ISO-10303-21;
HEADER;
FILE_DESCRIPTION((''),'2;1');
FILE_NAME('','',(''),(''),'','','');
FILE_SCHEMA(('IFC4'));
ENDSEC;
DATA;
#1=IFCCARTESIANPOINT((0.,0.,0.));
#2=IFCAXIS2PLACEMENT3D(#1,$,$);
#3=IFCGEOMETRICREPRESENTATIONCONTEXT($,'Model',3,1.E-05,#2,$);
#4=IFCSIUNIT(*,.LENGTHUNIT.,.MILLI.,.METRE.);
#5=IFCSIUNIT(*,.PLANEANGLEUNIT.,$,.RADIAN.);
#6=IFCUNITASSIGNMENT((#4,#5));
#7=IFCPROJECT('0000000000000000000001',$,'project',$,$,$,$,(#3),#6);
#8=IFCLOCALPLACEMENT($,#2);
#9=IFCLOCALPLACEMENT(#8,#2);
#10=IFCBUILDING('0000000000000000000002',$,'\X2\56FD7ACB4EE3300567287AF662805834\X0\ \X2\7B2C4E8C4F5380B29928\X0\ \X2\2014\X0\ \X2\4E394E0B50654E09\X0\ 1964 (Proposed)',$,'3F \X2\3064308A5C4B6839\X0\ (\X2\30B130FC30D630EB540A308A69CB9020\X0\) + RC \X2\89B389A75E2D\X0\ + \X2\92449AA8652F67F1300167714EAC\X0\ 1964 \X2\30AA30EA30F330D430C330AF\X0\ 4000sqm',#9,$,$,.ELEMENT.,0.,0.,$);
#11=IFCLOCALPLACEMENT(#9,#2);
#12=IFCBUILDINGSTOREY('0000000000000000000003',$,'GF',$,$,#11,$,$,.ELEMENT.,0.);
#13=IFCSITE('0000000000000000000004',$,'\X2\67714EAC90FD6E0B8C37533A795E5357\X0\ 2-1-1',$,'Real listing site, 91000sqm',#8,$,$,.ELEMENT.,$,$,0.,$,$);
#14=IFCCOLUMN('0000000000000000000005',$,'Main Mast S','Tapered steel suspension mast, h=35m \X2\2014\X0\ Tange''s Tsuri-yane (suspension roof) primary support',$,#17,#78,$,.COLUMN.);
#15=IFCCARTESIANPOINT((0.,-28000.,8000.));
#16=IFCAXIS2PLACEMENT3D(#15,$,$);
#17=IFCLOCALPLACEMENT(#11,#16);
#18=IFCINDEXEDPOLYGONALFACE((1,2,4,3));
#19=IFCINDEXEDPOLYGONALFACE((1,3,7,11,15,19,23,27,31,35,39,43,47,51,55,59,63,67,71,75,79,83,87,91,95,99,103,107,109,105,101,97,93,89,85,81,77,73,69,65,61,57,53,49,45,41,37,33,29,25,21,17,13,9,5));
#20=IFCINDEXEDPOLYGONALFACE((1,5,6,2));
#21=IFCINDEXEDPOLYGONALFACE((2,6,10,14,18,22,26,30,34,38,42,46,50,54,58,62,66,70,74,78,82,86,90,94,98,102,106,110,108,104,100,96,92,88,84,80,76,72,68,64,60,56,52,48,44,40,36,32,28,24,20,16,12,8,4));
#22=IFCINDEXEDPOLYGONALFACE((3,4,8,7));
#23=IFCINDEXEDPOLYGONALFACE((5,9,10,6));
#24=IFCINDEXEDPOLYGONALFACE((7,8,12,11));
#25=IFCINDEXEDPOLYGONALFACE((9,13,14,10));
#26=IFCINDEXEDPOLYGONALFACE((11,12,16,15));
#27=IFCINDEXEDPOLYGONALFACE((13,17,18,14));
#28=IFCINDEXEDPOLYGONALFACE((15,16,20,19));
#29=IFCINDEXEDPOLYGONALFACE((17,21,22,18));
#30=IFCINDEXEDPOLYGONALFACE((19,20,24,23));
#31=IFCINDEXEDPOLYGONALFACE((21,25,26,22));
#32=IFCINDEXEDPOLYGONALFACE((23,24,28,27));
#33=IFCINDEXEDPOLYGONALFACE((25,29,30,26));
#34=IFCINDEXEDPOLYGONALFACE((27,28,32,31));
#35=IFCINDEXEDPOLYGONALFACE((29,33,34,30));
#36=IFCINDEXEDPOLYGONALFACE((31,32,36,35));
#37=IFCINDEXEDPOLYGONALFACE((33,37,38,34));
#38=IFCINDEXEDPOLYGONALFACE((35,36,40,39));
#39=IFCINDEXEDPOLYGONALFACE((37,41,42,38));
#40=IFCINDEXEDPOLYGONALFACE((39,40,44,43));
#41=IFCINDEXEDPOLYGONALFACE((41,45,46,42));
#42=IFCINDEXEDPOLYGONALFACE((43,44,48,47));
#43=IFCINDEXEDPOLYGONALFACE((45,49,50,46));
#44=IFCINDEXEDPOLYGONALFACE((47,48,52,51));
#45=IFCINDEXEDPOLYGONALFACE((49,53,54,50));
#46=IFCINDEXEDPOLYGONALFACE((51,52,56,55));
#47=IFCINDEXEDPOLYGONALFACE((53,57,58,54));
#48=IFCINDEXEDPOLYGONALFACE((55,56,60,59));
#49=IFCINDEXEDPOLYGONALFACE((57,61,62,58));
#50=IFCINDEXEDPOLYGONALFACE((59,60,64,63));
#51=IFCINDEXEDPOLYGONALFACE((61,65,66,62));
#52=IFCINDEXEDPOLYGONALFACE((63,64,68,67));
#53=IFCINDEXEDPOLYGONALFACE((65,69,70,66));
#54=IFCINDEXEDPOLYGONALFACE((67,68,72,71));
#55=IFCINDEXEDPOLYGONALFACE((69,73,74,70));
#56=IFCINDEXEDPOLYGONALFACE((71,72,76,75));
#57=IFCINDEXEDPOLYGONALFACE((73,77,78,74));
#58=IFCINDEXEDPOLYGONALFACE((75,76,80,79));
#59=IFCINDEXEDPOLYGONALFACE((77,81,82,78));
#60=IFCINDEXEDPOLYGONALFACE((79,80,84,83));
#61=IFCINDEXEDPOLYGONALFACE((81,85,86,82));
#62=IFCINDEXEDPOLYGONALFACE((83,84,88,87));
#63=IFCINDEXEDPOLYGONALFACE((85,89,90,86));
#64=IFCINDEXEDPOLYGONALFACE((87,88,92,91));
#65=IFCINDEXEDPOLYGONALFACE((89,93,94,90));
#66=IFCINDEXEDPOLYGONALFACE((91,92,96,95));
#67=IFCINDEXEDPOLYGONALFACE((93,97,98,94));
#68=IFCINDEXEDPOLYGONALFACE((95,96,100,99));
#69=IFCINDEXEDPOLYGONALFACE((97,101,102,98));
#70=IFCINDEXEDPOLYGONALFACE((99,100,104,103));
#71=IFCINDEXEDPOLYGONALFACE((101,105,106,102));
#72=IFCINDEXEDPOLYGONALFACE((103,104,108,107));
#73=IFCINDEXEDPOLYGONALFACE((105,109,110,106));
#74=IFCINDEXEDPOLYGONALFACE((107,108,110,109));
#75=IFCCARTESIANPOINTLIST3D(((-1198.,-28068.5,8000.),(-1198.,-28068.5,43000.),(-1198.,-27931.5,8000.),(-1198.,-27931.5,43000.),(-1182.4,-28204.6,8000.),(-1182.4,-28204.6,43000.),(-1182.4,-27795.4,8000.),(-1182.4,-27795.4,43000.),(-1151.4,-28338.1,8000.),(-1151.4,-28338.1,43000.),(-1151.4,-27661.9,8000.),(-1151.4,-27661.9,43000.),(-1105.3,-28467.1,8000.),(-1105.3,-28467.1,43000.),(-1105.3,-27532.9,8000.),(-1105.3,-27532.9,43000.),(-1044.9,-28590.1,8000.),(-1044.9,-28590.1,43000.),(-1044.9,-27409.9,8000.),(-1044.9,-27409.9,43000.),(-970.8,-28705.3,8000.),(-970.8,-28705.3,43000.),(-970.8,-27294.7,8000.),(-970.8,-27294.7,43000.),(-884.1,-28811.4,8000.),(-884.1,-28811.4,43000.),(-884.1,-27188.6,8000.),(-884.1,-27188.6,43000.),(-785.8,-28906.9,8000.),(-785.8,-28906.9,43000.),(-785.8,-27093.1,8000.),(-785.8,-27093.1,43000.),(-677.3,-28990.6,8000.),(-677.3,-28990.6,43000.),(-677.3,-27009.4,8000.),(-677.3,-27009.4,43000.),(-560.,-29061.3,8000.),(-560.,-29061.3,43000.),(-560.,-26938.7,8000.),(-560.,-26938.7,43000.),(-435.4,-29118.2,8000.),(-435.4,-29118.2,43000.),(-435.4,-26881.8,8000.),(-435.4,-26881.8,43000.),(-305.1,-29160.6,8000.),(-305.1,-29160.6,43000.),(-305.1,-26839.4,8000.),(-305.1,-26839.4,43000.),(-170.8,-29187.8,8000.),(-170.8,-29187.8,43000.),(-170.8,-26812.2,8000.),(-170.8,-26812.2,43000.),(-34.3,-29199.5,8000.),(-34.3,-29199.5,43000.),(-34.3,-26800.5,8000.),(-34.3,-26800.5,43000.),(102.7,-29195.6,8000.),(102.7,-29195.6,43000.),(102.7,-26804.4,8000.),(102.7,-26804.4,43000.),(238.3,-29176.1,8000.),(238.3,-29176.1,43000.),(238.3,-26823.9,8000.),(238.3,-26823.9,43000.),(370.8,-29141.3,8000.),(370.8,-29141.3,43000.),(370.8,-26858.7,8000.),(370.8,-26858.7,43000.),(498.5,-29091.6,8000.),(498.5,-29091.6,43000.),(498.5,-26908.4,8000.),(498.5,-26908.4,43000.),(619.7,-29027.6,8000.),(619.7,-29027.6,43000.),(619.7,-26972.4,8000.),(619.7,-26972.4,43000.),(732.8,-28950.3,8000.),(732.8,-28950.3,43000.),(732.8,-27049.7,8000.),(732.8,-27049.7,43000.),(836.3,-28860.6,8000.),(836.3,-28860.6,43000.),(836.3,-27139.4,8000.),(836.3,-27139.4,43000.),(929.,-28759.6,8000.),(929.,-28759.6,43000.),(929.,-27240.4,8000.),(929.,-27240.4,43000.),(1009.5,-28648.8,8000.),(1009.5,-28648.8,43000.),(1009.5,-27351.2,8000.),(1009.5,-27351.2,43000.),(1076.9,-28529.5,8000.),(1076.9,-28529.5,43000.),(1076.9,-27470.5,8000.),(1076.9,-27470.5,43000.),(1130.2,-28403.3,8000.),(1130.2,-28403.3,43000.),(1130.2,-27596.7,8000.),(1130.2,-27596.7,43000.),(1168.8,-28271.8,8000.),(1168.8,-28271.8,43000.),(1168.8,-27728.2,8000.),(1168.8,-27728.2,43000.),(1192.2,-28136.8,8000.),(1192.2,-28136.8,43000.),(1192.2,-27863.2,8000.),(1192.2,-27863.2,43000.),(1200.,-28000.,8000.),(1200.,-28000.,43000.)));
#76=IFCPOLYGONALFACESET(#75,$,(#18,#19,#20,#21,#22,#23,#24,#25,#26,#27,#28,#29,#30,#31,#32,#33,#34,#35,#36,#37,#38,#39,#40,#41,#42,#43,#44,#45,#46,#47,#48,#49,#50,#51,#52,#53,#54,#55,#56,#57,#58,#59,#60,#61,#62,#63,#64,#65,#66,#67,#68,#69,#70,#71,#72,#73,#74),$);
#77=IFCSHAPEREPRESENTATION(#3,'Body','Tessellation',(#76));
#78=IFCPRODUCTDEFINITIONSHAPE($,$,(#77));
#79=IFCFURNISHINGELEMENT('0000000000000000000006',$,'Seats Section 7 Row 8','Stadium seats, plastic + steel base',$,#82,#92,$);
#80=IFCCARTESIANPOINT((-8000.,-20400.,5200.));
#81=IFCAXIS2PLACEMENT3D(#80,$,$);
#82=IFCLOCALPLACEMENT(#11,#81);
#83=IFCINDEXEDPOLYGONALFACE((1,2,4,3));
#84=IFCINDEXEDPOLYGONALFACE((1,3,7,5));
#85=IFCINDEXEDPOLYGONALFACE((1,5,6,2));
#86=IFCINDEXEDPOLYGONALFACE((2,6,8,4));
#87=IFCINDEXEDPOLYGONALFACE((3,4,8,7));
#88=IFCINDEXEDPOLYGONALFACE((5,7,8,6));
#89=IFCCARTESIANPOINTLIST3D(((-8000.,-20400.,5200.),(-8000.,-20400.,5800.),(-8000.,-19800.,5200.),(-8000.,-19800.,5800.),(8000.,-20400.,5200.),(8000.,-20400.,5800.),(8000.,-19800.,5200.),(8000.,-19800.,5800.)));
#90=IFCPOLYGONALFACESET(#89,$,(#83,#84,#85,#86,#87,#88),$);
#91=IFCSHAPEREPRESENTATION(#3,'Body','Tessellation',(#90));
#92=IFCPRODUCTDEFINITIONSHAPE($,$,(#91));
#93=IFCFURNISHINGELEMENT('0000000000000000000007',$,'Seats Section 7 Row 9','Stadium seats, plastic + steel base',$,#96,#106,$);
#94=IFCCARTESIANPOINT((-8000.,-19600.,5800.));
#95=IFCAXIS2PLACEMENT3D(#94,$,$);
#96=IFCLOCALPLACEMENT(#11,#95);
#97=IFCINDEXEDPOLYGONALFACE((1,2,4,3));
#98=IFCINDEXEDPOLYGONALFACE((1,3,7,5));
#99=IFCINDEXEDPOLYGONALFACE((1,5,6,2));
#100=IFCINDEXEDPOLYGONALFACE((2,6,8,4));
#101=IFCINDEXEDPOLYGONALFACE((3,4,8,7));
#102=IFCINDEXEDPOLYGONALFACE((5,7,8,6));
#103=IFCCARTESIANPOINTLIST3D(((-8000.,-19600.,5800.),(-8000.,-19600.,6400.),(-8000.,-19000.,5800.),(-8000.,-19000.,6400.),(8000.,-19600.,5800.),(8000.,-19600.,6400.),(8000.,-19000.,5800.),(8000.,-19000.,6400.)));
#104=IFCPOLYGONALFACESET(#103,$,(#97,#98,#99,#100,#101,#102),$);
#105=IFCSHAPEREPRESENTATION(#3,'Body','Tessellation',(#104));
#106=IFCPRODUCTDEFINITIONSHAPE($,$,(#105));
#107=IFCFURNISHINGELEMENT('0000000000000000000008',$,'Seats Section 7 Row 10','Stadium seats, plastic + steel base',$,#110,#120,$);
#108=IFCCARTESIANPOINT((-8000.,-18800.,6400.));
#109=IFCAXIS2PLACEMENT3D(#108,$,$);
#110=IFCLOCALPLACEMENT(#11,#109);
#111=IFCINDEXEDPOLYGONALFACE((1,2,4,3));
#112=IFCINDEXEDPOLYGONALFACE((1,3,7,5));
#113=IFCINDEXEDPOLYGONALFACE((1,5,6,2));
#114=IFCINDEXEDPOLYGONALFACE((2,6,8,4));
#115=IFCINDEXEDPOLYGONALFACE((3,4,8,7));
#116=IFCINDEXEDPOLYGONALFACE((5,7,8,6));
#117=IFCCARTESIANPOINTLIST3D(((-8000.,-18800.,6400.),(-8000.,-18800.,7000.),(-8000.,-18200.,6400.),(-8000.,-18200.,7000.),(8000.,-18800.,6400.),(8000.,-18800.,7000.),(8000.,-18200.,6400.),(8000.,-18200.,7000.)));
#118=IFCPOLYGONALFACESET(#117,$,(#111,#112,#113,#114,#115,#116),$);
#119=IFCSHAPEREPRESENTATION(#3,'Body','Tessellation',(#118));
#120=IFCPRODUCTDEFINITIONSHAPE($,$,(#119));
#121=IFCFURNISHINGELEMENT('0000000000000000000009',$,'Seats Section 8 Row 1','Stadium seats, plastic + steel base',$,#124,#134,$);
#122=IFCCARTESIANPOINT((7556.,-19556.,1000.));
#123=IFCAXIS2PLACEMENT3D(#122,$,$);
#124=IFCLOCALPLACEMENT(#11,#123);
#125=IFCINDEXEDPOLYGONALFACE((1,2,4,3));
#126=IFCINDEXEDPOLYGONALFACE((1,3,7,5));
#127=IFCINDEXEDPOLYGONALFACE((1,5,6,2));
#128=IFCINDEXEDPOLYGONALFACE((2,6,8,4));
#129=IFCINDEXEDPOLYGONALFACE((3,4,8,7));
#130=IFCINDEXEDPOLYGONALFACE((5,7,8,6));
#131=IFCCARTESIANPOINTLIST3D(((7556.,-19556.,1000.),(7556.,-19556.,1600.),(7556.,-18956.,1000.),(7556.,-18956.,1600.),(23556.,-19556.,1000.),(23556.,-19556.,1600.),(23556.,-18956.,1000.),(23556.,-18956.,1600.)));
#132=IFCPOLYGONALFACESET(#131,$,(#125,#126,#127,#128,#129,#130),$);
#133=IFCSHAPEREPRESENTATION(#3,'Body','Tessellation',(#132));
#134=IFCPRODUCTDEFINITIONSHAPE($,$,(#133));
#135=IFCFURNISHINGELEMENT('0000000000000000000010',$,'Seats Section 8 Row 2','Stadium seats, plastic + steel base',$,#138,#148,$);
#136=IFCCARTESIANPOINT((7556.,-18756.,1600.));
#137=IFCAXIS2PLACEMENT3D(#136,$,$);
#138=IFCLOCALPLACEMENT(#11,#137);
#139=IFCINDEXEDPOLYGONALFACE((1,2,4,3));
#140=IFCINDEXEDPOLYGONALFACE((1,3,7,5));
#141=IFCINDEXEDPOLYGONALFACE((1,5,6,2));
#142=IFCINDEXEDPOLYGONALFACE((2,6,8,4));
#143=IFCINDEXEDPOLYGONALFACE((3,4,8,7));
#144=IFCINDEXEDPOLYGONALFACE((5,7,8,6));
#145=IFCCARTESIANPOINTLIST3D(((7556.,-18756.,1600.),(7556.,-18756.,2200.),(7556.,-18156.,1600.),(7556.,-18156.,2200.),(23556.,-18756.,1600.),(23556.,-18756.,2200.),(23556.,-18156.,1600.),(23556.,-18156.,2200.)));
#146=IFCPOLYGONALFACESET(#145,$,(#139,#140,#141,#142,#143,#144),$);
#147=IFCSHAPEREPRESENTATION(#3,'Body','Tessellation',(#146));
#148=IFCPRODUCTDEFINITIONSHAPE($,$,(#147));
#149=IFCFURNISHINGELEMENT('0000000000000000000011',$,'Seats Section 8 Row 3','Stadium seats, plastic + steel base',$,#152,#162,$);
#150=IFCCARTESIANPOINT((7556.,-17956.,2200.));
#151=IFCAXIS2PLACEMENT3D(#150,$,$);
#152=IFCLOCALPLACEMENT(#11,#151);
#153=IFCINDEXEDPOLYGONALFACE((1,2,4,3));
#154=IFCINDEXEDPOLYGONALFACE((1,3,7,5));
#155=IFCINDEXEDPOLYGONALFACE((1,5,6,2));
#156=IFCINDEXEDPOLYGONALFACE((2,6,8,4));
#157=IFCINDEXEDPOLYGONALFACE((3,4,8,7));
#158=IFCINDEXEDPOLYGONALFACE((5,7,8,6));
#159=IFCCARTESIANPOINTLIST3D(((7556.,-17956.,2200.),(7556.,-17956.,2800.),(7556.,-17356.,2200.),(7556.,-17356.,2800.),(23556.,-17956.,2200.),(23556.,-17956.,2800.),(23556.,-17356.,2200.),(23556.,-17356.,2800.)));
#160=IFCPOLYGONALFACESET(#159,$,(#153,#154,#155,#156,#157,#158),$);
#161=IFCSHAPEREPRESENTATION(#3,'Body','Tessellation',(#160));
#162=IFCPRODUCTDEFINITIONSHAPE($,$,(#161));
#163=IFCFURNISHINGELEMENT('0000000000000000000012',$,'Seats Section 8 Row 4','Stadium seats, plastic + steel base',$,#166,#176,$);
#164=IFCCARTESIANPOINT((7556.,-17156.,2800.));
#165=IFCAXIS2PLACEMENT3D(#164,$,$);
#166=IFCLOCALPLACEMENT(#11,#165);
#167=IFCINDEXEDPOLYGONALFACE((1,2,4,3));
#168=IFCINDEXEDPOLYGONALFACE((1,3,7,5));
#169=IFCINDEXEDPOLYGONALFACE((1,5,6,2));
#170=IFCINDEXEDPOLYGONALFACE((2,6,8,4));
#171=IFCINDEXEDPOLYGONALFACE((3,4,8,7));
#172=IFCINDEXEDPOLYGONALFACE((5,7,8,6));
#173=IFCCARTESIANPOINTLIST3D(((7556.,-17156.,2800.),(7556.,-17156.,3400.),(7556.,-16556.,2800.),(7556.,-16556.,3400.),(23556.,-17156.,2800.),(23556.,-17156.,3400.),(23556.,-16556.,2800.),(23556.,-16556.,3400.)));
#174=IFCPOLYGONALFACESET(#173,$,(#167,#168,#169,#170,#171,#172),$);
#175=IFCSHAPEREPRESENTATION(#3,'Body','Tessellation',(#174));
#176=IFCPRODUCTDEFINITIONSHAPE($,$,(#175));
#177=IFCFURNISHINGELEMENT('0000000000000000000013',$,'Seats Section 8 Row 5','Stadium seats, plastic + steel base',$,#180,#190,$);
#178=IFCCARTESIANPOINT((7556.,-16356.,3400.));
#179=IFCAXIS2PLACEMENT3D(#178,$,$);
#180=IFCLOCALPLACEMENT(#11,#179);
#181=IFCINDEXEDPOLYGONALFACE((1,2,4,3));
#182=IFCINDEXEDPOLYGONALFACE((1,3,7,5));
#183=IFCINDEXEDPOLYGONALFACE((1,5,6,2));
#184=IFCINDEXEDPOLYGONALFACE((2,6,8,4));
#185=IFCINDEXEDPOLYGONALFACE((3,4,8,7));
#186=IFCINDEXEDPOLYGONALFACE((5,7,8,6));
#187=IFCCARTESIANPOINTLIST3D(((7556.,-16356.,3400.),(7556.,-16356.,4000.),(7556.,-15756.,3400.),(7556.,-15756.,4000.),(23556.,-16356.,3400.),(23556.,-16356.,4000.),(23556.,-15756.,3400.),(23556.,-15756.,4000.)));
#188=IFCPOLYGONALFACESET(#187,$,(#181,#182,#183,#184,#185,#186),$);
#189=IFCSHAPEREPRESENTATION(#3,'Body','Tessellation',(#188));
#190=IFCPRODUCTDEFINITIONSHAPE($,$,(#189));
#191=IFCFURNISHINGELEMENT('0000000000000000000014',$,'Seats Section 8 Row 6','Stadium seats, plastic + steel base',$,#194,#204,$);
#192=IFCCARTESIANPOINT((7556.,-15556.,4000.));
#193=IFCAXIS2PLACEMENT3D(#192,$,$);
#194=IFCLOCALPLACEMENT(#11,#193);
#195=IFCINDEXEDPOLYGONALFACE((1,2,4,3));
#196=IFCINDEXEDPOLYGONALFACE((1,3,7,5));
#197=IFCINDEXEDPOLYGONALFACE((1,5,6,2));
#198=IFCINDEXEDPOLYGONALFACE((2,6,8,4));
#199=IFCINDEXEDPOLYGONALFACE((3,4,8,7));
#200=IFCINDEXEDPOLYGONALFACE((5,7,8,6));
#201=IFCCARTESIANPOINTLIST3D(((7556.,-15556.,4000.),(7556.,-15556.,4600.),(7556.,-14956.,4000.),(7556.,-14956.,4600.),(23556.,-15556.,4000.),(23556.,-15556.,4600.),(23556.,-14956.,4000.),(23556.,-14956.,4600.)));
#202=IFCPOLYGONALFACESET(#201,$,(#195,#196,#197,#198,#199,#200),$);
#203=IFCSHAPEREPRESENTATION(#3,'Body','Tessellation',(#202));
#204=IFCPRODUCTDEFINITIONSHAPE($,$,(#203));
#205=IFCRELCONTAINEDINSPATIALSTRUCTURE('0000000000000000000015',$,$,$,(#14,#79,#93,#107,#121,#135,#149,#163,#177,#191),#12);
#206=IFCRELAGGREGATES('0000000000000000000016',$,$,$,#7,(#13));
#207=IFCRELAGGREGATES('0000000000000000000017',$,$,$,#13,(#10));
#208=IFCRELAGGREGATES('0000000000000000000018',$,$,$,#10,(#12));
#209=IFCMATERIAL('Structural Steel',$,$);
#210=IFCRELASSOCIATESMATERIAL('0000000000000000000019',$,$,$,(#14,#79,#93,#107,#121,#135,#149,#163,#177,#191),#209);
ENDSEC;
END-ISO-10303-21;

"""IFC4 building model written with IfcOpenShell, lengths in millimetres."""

from ifc_helpers import new_model, si_unit, frame, frame_2d, origin, origin_2d, place, context, project, spatial, rectangle, circle, extrude, material, element, save


model = new_model("IFC4")

# Units and contexts
model_context = context("Model", 3, precision=1e-05, world=origin())
ifc_project = project(units=[si_unit("LENGTHUNIT", "METRE", prefix="MILLI"), si_unit("PLANEANGLEUNIT", "RADIAN")], contexts=[model_context])

# Site, building, storey
site_placement = place(None, origin())
site = spatial("IfcSite", under=ifc_project, at=site_placement, Name="東京都渋谷区神南 2-1-1", ObjectType="Real listing site, 91000sqm", CompositionType="ELEMENT", RefElevation=0.0)
building_placement = place(site_placement, origin())
building = spatial("IfcBuilding", under=site, at=building_placement, Name="国立代々木競技場 第二体育館 — 丹下健三 1964 (Proposed)", ObjectType="3F つり屋根 (ケーブル吊り構造) + RC 観覧席 + 鉄骨支柱、東京 1964 オリンピック 4000sqm", CompositionType="ELEMENT", ElevationOfRefHeight=0.0, ElevationOfTerrain=0.0)
storey_placement = place(building_placement, origin())
storey = spatial("IfcBuildingStorey", under=building, at=storey_placement, Name="GF", CompositionType="ELEMENT", Elevation=0.0)

# Column
ifc_material_1 = material(Name="Structural Steel")
column_placement = place(storey_placement, frame((0.0, -28000.0, 8000.0)))
element("IfcColumn", 1, at=column_placement, inside=storey, material=ifc_material_1, Name="Main Mast S", Description="Tapered steel suspension mast, h=35m — Tange's Tsuri-yane (suspension roof) primary support", PredefinedType="COLUMN", context=model_context, shape_type="SweptSolid", body=[
    extrude(circle(Radius=1200.0, at=origin_2d()), frame((0.0, -28000.0, 8000.0)), (0.0, 0.0, 1.0), 35000.0),
])

# Furnishing elements
furnishing_1_placement = place(storey_placement, frame((-8000.0, -20400.0, 5200.0)))
element("IfcFurnishingElement", 2, at=furnishing_1_placement, inside=storey, material=ifc_material_1, Name="Seats Section 7 Row 8", Description="Stadium seats, plastic + steel base", context=model_context, shape_type="SweptSolid", body=[
    extrude(rectangle(XDim=16000.0, YDim=600.0, at=frame_2d((8000.0, 300.0))), frame((-8000.0, -20400.0, 5200.0)), (0.0, 0.0, 1.0), 600.0),
])
furnishing_2_placement = place(storey_placement, frame((-8000.0, -19600.0, 5800.0)))
element("IfcFurnishingElement", 3, at=furnishing_2_placement, inside=storey, material=ifc_material_1, Name="Seats Section 7 Row 9", Description="Stadium seats, plastic + steel base", context=model_context, shape_type="SweptSolid", body=[
    extrude(rectangle(XDim=16000.0, YDim=600.0, at=frame_2d((8000.0, 300.0))), frame((-8000.0, -19600.0, 5800.0)), (0.0, 0.0, 1.0), 600.0),
])
furnishing_3_placement = place(storey_placement, frame((-8000.0, -18800.0, 6400.0)))
element("IfcFurnishingElement", 4, at=furnishing_3_placement, inside=storey, material=ifc_material_1, Name="Seats Section 7 Row 10", Description="Stadium seats, plastic + steel base", context=model_context, shape_type="SweptSolid", body=[
    extrude(rectangle(XDim=16000.0, YDim=600.0, at=frame_2d((8000.0, 300.0))), frame((-8000.0, -18800.0, 6400.0)), (0.0, 0.0, 1.0), 600.0),
])
furnishing_4_placement = place(storey_placement, frame((7556.0, -19556.0, 1000.0)))
element("IfcFurnishingElement", 5, at=furnishing_4_placement, inside=storey, material=ifc_material_1, Name="Seats Section 8 Row 1", Description="Stadium seats, plastic + steel base", context=model_context, shape_type="SweptSolid", body=[
    extrude(rectangle(XDim=16000.0, YDim=600.0, at=frame_2d((8000.0, 300.0))), frame((7556.0, -19556.0, 1000.0)), (0.0, 0.0, 1.0), 600.0),
])
furnishing_5_placement = place(storey_placement, frame((7556.0, -18756.0, 1600.0)))
element("IfcFurnishingElement", 6, at=furnishing_5_placement, inside=storey, material=ifc_material_1, Name="Seats Section 8 Row 2", Description="Stadium seats, plastic + steel base", context=model_context, shape_type="SweptSolid", body=[
    extrude(rectangle(XDim=16000.0, YDim=600.0, at=frame_2d((8000.0, 300.0))), frame((7556.0, -18756.0, 1600.0)), (0.0, 0.0, 1.0), 600.0),
])
furnishing_6_placement = place(storey_placement, frame((7556.0, -17956.0, 2200.0)))
element("IfcFurnishingElement", 7, at=furnishing_6_placement, inside=storey, material=ifc_material_1, Name="Seats Section 8 Row 3", Description="Stadium seats, plastic + steel base", context=model_context, shape_type="SweptSolid", body=[
    extrude(rectangle(XDim=16000.0, YDim=600.0, at=frame_2d((8000.0, 300.0))), frame((7556.0, -17956.0, 2200.0)), (0.0, 0.0, 1.0), 600.0),
])
furnishing_7_placement = place(storey_placement, frame((7556.0, -17156.0, 2800.0)))
element("IfcFurnishingElement", 8, at=furnishing_7_placement, inside=storey, material=ifc_material_1, Name="Seats Section 8 Row 4", Description="Stadium seats, plastic + steel base", context=model_context, shape_type="SweptSolid", body=[
    extrude(rectangle(XDim=16000.0, YDim=600.0, at=frame_2d((8000.0, 300.0))), frame((7556.0, -17156.0, 2800.0)), (0.0, 0.0, 1.0), 600.0),
])
furnishing_8_placement = place(storey_placement, frame((7556.0, -16356.0, 3400.0)))
element("IfcFurnishingElement", 9, at=furnishing_8_placement, inside=storey, material=ifc_material_1, Name="Seats Section 8 Row 5", Description="Stadium seats, plastic + steel base", context=model_context, shape_type="SweptSolid", body=[
    extrude(rectangle(XDim=16000.0, YDim=600.0, at=frame_2d((8000.0, 300.0))), frame((7556.0, -16356.0, 3400.0)), (0.0, 0.0, 1.0), 600.0),
])
furnishing_9_placement = place(storey_placement, frame((7556.0, -15556.0, 4000.0)))
element("IfcFurnishingElement", 10, at=furnishing_9_placement, inside=storey, material=ifc_material_1, Name="Seats Section 8 Row 6", Description="Stadium seats, plastic + steel base", context=model_context, shape_type="SweptSolid", body=[
    extrude(rectangle(XDim=16000.0, YDim=600.0, at=frame_2d((8000.0, 300.0))), frame((7556.0, -15556.0, 4000.0)), (0.0, 0.0, 1.0), 600.0),
])

save(model, "model.ifc")
